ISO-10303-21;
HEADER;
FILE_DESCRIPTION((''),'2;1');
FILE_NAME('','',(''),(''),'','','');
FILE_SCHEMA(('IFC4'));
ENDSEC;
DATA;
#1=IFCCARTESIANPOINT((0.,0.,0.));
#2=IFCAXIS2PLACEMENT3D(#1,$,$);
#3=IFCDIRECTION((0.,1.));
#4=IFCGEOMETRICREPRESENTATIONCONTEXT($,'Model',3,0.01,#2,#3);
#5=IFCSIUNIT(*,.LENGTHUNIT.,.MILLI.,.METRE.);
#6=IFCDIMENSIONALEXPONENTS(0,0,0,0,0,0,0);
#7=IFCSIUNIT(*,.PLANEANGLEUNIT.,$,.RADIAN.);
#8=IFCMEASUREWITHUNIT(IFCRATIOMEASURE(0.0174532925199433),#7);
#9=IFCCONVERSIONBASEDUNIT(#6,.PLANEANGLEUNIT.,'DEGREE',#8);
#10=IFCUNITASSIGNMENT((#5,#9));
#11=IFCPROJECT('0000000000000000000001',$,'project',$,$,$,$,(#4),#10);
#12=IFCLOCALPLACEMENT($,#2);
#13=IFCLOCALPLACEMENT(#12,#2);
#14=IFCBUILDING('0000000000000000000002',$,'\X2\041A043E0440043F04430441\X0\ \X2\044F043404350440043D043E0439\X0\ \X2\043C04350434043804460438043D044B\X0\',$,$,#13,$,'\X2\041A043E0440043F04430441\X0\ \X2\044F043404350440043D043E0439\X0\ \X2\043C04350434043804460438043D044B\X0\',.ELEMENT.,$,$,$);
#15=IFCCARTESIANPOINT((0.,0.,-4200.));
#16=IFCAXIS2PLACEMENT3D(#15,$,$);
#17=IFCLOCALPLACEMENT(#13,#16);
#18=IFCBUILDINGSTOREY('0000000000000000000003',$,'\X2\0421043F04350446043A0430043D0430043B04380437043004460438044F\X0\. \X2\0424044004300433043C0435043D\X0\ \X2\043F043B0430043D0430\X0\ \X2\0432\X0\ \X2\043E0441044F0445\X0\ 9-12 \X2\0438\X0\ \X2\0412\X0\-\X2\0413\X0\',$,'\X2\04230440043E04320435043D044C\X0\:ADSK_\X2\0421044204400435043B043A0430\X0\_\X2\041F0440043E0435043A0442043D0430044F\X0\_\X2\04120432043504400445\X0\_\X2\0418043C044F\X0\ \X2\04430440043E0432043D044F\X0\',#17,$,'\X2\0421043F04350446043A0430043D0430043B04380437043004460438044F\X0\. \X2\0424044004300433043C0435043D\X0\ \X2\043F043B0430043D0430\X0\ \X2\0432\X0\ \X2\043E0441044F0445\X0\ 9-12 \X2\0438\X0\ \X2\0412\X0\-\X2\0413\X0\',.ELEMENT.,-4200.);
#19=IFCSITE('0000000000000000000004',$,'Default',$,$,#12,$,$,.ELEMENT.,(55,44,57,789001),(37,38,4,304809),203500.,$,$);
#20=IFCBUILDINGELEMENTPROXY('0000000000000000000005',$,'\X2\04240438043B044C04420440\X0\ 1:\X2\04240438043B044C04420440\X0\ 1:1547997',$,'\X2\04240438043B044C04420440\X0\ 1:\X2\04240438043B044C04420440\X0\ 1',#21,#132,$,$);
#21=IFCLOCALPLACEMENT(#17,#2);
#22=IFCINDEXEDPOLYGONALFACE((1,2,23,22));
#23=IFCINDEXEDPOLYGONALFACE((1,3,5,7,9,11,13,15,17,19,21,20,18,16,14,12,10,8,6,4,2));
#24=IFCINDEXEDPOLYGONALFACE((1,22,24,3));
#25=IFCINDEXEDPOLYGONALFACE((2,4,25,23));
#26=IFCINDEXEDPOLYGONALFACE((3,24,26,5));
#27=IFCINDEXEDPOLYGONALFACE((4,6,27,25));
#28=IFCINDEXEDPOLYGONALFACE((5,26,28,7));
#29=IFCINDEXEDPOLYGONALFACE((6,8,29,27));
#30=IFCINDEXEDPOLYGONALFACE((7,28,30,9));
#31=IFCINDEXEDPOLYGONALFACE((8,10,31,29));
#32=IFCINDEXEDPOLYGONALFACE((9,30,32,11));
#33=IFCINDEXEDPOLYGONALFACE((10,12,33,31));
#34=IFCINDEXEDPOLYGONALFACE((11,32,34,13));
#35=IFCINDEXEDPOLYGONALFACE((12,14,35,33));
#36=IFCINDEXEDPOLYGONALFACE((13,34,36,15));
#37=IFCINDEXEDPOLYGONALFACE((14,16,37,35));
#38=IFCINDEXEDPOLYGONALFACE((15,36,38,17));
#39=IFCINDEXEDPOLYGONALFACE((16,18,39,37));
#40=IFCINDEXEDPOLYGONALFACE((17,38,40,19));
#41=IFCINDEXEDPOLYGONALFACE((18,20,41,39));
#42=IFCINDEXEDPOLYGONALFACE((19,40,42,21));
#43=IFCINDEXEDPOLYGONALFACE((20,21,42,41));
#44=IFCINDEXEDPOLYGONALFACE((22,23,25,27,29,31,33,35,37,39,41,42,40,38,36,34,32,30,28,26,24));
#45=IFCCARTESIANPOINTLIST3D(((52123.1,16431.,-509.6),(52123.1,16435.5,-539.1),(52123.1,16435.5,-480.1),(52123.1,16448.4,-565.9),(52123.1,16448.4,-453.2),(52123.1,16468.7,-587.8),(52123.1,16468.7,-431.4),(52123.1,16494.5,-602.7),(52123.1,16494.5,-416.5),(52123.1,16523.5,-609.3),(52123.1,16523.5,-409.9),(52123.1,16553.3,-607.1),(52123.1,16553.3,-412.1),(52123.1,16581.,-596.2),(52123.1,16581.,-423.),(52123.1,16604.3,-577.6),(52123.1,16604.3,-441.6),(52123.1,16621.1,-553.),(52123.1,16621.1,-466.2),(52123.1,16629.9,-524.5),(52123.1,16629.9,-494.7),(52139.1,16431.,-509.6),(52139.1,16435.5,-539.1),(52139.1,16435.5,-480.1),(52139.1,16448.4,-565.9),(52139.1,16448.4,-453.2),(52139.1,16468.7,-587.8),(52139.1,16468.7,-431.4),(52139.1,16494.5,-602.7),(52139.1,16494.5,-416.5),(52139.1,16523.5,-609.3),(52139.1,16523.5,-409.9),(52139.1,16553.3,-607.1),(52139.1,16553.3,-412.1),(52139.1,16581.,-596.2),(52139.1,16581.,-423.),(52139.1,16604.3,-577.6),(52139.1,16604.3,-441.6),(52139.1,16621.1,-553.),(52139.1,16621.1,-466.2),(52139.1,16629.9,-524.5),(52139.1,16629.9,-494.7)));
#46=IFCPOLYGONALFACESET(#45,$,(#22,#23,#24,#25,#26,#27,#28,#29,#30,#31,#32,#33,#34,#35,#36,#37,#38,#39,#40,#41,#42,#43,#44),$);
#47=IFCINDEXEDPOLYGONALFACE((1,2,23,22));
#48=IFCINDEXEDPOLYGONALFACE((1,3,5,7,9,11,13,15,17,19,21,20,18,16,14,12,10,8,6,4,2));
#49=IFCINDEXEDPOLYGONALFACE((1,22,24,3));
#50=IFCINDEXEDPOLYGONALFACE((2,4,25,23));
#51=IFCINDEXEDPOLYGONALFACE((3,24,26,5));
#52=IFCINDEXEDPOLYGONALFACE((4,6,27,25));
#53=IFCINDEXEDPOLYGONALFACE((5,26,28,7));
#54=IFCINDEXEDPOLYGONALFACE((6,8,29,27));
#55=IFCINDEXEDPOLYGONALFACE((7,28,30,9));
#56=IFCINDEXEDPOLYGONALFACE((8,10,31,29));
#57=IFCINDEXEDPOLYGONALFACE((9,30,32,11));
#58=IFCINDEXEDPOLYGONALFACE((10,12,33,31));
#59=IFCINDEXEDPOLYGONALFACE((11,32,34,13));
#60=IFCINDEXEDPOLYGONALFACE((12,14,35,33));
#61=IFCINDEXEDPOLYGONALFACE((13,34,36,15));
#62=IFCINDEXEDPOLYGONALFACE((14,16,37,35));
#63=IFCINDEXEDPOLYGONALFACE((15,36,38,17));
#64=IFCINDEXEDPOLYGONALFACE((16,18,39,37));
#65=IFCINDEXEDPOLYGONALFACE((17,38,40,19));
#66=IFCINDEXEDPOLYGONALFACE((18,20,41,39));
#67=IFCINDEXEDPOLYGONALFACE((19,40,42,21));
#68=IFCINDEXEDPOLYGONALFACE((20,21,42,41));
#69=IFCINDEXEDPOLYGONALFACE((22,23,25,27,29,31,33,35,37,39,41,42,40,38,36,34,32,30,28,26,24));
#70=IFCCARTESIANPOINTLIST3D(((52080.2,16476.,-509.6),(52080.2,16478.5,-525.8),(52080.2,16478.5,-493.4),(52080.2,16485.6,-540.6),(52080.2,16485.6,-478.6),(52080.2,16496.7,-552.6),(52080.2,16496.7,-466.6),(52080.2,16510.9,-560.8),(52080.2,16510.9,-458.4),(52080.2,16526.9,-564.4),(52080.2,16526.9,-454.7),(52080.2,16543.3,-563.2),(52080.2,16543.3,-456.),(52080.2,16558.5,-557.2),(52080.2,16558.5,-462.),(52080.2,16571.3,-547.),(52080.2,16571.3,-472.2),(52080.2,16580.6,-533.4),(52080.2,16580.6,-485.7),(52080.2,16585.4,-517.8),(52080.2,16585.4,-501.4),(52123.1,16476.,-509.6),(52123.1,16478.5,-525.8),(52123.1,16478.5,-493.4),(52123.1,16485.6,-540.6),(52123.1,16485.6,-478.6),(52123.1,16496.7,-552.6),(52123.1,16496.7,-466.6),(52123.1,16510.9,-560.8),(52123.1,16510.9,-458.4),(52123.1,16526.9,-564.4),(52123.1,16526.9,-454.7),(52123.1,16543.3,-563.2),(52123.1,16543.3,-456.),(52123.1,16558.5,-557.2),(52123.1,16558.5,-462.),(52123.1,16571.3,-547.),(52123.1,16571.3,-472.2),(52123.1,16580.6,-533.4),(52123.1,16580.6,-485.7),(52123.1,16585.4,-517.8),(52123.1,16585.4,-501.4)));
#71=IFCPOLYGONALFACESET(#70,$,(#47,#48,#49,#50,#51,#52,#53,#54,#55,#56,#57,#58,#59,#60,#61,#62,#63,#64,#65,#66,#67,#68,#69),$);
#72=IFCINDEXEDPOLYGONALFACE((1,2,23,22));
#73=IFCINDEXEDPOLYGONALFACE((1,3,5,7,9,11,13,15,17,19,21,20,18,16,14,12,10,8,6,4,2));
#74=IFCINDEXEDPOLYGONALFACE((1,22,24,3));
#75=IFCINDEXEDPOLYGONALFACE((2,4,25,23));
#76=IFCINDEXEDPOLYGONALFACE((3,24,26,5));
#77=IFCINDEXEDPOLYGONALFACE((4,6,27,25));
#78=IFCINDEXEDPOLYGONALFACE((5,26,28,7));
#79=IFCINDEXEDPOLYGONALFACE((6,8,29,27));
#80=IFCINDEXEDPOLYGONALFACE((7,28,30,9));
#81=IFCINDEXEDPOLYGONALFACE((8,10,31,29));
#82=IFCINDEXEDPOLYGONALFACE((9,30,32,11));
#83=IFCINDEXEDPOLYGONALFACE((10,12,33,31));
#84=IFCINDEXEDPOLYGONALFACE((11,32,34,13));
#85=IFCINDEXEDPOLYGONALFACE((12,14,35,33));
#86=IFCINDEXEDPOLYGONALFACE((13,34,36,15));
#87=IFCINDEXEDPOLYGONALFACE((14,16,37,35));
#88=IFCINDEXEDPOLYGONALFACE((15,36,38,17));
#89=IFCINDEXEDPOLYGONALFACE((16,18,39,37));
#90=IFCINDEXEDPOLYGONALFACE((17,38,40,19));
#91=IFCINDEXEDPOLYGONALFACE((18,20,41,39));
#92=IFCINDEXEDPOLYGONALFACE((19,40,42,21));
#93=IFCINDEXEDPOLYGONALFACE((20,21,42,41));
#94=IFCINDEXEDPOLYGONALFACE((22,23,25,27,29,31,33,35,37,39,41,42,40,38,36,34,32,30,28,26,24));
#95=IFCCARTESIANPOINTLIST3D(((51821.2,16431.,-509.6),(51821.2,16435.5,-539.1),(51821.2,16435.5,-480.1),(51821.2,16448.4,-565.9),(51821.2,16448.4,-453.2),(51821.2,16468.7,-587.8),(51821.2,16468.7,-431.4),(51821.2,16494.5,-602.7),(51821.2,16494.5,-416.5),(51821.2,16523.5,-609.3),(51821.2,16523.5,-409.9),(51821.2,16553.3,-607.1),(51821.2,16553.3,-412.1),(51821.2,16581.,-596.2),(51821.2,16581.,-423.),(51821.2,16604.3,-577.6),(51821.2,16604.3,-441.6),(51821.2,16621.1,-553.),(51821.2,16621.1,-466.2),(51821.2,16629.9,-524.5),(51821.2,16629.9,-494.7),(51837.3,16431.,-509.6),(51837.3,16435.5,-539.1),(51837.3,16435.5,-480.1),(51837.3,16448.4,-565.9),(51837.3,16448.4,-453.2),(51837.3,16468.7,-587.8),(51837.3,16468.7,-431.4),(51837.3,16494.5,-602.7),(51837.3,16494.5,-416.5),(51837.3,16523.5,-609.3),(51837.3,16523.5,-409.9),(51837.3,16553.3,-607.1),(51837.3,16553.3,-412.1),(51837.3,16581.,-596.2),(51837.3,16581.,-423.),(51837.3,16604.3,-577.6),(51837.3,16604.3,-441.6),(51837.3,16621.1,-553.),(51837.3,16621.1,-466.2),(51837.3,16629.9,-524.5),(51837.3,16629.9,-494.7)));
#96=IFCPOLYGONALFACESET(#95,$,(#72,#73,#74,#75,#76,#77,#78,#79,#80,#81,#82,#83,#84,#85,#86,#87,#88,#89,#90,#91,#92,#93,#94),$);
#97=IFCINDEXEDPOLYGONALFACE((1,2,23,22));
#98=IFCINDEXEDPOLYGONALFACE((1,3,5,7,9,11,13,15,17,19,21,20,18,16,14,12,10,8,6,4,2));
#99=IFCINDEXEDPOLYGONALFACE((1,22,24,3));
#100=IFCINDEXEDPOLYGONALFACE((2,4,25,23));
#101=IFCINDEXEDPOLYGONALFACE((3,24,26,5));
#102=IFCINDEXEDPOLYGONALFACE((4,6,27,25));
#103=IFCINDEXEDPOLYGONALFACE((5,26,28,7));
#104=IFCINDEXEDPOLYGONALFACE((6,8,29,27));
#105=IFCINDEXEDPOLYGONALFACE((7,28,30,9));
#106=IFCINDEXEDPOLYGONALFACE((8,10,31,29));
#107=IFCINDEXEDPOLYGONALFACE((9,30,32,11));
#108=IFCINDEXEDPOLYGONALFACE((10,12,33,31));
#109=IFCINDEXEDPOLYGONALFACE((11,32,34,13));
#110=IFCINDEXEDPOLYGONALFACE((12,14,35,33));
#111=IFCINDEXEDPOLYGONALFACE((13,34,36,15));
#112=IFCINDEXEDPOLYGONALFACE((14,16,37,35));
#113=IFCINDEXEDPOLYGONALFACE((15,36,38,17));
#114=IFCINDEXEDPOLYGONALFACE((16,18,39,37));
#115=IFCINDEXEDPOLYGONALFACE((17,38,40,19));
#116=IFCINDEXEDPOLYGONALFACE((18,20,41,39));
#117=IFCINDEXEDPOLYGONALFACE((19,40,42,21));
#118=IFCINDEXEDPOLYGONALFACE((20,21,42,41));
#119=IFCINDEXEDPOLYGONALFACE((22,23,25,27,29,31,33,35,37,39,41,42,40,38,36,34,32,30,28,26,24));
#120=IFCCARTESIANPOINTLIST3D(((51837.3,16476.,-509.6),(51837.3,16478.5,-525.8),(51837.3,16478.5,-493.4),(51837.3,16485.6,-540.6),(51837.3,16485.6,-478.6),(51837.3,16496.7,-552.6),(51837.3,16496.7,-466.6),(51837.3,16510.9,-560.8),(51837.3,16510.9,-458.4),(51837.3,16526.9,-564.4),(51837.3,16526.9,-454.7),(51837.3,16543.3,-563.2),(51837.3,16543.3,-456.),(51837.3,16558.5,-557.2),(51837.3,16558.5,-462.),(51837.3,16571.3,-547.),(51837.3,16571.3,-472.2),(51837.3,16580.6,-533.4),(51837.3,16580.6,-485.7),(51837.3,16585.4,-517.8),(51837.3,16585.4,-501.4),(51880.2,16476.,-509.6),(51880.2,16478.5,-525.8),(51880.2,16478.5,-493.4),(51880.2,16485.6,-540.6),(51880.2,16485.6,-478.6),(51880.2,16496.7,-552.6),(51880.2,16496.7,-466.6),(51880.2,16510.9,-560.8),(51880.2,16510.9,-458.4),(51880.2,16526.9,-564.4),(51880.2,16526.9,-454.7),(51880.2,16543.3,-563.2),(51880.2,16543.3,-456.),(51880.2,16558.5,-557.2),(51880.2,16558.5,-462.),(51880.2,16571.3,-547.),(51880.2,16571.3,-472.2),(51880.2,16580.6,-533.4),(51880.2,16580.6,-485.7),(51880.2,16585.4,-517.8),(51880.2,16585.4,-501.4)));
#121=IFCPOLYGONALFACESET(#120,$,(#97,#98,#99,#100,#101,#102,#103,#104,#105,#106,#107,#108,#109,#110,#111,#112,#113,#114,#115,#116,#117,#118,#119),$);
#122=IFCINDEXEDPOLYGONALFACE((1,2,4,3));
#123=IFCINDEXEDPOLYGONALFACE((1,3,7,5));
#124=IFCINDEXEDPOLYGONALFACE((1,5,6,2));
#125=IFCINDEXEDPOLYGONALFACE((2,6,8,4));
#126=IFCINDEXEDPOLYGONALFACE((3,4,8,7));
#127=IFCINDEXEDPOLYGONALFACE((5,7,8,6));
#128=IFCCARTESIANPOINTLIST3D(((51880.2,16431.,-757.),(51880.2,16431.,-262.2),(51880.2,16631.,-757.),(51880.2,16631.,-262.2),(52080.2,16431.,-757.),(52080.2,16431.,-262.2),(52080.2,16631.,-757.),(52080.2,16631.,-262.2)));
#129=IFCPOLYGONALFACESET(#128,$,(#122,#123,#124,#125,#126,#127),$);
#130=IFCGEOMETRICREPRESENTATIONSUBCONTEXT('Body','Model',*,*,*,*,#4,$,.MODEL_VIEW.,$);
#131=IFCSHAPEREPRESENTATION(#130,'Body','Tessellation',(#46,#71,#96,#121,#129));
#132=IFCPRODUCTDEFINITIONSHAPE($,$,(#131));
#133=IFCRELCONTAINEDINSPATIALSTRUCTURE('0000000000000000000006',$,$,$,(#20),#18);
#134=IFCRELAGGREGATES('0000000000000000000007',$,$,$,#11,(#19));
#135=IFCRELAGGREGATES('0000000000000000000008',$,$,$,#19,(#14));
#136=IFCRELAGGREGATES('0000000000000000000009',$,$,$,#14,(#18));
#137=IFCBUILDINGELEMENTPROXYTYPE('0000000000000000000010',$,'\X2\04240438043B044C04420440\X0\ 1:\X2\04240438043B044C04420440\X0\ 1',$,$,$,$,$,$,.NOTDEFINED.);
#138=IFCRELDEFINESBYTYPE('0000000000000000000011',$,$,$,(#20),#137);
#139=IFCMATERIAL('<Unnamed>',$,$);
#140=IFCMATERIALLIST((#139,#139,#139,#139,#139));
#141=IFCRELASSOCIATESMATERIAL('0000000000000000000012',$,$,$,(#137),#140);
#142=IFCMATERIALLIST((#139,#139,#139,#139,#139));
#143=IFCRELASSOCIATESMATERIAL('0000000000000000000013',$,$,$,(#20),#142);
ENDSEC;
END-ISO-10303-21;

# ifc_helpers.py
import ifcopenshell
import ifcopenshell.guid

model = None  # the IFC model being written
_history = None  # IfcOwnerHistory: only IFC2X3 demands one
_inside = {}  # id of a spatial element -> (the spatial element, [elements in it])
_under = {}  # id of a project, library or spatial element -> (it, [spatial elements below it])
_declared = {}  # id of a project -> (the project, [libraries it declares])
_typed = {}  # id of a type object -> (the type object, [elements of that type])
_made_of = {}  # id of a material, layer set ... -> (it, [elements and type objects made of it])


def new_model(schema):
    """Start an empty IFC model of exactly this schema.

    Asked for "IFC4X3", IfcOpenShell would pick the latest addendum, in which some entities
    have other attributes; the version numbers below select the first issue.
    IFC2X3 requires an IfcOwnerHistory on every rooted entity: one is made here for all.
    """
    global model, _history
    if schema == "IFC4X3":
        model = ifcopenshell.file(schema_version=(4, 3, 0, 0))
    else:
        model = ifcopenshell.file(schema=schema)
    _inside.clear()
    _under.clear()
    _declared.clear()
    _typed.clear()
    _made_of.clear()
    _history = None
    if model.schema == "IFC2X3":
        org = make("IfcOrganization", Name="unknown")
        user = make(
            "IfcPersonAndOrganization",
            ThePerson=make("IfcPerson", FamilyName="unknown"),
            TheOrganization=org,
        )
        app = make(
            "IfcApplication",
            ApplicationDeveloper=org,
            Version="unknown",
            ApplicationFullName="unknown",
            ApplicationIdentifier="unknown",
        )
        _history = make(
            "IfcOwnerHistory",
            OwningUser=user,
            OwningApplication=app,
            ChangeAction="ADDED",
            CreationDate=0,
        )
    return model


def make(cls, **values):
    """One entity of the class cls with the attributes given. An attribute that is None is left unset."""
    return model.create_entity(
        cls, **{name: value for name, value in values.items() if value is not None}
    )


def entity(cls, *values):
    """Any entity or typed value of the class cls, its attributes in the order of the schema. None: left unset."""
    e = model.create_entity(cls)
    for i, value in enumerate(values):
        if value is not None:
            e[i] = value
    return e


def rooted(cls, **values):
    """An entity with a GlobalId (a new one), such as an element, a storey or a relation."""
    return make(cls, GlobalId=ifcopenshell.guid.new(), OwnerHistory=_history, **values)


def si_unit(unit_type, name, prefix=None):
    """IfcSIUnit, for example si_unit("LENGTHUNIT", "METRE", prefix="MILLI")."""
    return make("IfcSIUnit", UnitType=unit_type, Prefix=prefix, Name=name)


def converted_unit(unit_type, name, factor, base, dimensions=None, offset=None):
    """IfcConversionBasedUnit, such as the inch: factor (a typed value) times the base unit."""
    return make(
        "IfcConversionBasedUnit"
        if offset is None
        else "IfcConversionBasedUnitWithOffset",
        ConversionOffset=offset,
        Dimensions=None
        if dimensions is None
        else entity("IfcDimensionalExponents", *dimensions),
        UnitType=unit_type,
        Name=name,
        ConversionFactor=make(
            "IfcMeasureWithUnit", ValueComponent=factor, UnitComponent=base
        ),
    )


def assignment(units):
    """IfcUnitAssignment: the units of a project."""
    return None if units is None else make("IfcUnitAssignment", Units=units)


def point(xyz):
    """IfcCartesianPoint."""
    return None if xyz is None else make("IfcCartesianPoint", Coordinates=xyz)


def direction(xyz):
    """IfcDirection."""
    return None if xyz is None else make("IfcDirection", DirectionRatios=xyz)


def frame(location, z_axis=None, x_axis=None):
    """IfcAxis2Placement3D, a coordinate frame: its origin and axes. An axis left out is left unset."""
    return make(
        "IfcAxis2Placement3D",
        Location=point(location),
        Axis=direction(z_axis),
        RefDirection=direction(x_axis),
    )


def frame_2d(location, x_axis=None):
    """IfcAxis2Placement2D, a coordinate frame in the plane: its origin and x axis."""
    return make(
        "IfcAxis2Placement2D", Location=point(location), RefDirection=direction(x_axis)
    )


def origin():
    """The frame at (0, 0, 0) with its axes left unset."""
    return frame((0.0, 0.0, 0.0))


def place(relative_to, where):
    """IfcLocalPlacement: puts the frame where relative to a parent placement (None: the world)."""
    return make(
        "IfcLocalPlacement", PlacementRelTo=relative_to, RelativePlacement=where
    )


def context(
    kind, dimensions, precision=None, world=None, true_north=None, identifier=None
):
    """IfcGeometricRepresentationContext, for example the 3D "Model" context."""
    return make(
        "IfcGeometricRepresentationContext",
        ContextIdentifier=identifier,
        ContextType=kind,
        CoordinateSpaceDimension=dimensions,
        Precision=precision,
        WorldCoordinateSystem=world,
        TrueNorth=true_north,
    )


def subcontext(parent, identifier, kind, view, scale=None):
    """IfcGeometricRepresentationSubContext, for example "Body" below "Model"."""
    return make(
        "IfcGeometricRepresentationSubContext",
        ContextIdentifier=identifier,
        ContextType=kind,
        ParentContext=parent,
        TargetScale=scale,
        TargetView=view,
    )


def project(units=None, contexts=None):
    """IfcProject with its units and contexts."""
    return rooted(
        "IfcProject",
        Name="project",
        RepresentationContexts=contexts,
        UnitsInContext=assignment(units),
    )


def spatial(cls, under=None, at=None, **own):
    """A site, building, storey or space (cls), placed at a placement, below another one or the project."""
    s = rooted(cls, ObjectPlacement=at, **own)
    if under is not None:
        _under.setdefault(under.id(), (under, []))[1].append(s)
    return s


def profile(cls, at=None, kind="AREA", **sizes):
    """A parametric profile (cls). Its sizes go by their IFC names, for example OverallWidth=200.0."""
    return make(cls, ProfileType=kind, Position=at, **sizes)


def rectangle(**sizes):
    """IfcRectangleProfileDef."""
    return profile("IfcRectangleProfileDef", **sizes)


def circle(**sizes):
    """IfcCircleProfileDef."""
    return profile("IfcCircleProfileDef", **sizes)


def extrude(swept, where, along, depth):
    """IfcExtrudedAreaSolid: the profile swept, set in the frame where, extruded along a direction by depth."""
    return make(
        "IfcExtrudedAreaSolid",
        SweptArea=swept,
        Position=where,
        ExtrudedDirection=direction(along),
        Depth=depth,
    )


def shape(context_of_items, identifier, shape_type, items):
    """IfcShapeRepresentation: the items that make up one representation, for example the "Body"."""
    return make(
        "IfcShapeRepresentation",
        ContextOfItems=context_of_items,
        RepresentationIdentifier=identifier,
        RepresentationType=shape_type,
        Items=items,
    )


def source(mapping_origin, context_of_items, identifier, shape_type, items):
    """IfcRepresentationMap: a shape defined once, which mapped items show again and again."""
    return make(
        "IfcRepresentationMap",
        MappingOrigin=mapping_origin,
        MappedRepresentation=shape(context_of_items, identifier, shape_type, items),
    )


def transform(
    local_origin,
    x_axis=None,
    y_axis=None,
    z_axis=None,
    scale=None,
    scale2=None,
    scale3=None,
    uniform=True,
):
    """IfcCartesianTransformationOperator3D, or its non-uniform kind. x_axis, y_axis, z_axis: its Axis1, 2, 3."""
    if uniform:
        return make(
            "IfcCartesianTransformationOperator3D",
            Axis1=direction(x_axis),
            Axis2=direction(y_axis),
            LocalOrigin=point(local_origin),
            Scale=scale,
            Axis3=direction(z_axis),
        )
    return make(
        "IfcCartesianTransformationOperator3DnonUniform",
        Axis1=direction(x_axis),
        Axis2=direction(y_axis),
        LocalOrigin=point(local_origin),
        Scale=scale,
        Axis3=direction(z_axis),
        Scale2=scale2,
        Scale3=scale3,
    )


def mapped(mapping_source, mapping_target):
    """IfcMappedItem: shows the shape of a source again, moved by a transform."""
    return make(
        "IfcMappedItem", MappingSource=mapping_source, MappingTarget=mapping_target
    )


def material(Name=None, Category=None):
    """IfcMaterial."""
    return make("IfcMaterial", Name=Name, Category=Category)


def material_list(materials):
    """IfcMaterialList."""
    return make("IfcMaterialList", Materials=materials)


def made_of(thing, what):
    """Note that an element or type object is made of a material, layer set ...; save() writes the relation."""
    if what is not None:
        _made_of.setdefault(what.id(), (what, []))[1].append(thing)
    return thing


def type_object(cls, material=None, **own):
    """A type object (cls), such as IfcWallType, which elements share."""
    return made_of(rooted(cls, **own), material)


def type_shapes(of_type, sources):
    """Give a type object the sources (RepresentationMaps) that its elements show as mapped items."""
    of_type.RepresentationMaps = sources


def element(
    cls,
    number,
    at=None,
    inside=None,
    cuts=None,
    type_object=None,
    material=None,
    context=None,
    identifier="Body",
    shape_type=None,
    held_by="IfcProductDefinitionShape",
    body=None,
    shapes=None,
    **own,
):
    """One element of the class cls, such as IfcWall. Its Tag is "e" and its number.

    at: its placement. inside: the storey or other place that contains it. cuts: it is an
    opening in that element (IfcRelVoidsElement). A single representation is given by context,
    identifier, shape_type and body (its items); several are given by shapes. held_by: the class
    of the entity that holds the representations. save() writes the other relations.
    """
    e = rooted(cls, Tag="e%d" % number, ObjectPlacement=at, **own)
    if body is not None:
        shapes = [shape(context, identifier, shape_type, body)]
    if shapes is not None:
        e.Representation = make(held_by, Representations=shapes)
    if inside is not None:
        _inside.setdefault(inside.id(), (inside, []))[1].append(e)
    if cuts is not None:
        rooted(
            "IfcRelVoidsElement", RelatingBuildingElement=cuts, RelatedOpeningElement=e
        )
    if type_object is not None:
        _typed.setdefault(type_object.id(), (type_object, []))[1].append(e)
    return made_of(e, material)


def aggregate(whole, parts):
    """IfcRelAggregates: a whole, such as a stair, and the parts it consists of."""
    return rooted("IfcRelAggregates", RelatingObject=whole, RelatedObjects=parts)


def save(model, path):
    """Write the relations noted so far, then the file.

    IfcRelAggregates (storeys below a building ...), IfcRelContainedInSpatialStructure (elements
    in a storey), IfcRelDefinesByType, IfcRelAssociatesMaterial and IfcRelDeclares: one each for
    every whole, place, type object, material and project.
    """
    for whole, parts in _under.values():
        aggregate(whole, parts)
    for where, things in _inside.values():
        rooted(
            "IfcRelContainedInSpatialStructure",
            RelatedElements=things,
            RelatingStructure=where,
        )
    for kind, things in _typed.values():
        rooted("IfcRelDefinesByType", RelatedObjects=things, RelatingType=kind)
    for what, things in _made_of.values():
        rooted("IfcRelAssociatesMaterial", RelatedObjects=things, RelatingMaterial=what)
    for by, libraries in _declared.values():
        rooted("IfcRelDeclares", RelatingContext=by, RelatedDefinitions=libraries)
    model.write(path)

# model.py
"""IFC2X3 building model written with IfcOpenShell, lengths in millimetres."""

from ifc_helpers import new_model, entity, si_unit, converted_unit, direction, frame, frame_2d, origin, place, context, subcontext, project, spatial, rectangle, circle, extrude, source, transform, mapped, material, material_list, type_object, type_shapes, element, save


model = new_model("IFC2X3")

# Units and contexts
model_context = context("Model", 3, precision=0.01, world=origin(), true_north=direction((0.0, 1.0)))
body_context = subcontext(model_context, "Body", "Model", "MODEL_VIEW")
ifc_project = project(units=[si_unit("LENGTHUNIT", "METRE", prefix="MILLI"), converted_unit("PLANEANGLEUNIT", "DEGREE", entity("IfcRatioMeasure", 0.0174532925199433), si_unit("PLANEANGLEUNIT", "RADIAN"), dimensions=[0, 0, 0, 0, 0, 0, 0])], contexts=[model_context])

# Site, building, storey
site_placement = place(None, frame((0.0, 0.0, 0.0)))
site = spatial("IfcSite", under=ifc_project, at=site_placement, Name="Default", CompositionType="ELEMENT", RefLatitude=(55, 44, 57, 789001), RefLongitude=(37, 38, 4, 304809), RefElevation=203500.0)
building_placement = place(site_placement, origin())
building = spatial("IfcBuilding", under=site, at=building_placement, Name="Корпус ядерной медицины", LongName="Корпус ядерной медицины", CompositionType="ELEMENT")
storey_placement = place(building_placement, frame((0.0, 0.0, -4200.0)))
storey = spatial("IfcBuildingStorey", under=building, at=storey_placement, Name="Спецканализация. Фрагмен плана в осях 9-12 и В-Г", ObjectType="Уровень:ADSK_Стрелка_Проектная_Вверх_Имя уровня", LongName="Спецканализация. Фрагмен плана в осях 9-12 и В-Г", CompositionType="ELEMENT", Elevation=-4200.0)

# Building element proxy
ifc_material_1 = material(Name="<Unnamed>")
ifc_material_list_1 = material_list([ifc_material_1, ifc_material_1, ifc_material_1, ifc_material_1, ifc_material_1])
ifc_material_list_2 = material_list([ifc_material_1, ifc_material_1, ifc_material_1, ifc_material_1, ifc_material_1])
building_element_proxy_type_1 = type_object("IfcBuildingElementProxyType", Name="Фильтр 1:Фильтр 1", PredefinedType="NOTDEFINED", material=ifc_material_list_2)
shared_shape_1 = source(origin(), body_context, "Body", "SweptSolid", [
    extrude(circle(Radius=100.0, at=frame_2d((0.0, 0.0), x_axis=(1.0, 0.0))), frame((142.9, 0.0, 89.7), z_axis=(1.0, 0.0, 0.0), x_axis=(0.0, -1.0, 0.0)), (0.0, 0.0, 1.0), 16.1),
    extrude(circle(Radius=55.0, at=frame_2d((0.0, 0.0), x_axis=(1.0, 0.0))), frame((100.0, 0.0, 89.7), z_axis=(1.0, 0.0, 0.0), x_axis=(0.0, -1.0, 0.0)), (0.0, 0.0, 1.0), 42.9),
    extrude(circle(Radius=100.0, at=frame_2d((0.0, 0.0), x_axis=(1.0, 0.0))), frame((-158.9, 0.0, 89.7), z_axis=(1.0, 0.0, 0.0), x_axis=(0.0, -1.0, 0.0)), (0.0, 0.0, 1.0), 16.1),
    extrude(circle(Radius=55.0, at=frame_2d((0.0, 0.0), x_axis=(1.0, 0.0))), frame((-142.9, 0.0, 89.7), z_axis=(1.0, 0.0, 0.0), x_axis=(0.0, -1.0, 0.0)), (0.0, 0.0, 1.0), 42.9),
    extrude(rectangle(XDim=200.0, YDim=200.0, at=frame_2d((0.0, 0.0), x_axis=(1.0, 0.0))), frame((0.0, 0.0, -157.8), z_axis=(0.0, 0.0, 1.0), x_axis=(0.0, -1.0, 0.0)), (0.0, 0.0, 1.0), 494.9),
])
type_shapes(building_element_proxy_type_1, [shared_shape_1])
proxy_1_placement = place(storey_placement, frame((51980.2, 16531.0, -599.3)))
element("IfcBuildingElementProxy", 1, at=proxy_1_placement, inside=storey, type_object=building_element_proxy_type_1, material=ifc_material_list_1, Name="Фильтр 1:Фильтр 1:1547997", ObjectType="Фильтр 1:Фильтр 1", context=body_context, shape_type="MappedRepresentation", body=[
    mapped(shared_shape_1, transform((0.0, 0.0, 0.0), scale=1.0)),
])

save(model, "model.ifc")
